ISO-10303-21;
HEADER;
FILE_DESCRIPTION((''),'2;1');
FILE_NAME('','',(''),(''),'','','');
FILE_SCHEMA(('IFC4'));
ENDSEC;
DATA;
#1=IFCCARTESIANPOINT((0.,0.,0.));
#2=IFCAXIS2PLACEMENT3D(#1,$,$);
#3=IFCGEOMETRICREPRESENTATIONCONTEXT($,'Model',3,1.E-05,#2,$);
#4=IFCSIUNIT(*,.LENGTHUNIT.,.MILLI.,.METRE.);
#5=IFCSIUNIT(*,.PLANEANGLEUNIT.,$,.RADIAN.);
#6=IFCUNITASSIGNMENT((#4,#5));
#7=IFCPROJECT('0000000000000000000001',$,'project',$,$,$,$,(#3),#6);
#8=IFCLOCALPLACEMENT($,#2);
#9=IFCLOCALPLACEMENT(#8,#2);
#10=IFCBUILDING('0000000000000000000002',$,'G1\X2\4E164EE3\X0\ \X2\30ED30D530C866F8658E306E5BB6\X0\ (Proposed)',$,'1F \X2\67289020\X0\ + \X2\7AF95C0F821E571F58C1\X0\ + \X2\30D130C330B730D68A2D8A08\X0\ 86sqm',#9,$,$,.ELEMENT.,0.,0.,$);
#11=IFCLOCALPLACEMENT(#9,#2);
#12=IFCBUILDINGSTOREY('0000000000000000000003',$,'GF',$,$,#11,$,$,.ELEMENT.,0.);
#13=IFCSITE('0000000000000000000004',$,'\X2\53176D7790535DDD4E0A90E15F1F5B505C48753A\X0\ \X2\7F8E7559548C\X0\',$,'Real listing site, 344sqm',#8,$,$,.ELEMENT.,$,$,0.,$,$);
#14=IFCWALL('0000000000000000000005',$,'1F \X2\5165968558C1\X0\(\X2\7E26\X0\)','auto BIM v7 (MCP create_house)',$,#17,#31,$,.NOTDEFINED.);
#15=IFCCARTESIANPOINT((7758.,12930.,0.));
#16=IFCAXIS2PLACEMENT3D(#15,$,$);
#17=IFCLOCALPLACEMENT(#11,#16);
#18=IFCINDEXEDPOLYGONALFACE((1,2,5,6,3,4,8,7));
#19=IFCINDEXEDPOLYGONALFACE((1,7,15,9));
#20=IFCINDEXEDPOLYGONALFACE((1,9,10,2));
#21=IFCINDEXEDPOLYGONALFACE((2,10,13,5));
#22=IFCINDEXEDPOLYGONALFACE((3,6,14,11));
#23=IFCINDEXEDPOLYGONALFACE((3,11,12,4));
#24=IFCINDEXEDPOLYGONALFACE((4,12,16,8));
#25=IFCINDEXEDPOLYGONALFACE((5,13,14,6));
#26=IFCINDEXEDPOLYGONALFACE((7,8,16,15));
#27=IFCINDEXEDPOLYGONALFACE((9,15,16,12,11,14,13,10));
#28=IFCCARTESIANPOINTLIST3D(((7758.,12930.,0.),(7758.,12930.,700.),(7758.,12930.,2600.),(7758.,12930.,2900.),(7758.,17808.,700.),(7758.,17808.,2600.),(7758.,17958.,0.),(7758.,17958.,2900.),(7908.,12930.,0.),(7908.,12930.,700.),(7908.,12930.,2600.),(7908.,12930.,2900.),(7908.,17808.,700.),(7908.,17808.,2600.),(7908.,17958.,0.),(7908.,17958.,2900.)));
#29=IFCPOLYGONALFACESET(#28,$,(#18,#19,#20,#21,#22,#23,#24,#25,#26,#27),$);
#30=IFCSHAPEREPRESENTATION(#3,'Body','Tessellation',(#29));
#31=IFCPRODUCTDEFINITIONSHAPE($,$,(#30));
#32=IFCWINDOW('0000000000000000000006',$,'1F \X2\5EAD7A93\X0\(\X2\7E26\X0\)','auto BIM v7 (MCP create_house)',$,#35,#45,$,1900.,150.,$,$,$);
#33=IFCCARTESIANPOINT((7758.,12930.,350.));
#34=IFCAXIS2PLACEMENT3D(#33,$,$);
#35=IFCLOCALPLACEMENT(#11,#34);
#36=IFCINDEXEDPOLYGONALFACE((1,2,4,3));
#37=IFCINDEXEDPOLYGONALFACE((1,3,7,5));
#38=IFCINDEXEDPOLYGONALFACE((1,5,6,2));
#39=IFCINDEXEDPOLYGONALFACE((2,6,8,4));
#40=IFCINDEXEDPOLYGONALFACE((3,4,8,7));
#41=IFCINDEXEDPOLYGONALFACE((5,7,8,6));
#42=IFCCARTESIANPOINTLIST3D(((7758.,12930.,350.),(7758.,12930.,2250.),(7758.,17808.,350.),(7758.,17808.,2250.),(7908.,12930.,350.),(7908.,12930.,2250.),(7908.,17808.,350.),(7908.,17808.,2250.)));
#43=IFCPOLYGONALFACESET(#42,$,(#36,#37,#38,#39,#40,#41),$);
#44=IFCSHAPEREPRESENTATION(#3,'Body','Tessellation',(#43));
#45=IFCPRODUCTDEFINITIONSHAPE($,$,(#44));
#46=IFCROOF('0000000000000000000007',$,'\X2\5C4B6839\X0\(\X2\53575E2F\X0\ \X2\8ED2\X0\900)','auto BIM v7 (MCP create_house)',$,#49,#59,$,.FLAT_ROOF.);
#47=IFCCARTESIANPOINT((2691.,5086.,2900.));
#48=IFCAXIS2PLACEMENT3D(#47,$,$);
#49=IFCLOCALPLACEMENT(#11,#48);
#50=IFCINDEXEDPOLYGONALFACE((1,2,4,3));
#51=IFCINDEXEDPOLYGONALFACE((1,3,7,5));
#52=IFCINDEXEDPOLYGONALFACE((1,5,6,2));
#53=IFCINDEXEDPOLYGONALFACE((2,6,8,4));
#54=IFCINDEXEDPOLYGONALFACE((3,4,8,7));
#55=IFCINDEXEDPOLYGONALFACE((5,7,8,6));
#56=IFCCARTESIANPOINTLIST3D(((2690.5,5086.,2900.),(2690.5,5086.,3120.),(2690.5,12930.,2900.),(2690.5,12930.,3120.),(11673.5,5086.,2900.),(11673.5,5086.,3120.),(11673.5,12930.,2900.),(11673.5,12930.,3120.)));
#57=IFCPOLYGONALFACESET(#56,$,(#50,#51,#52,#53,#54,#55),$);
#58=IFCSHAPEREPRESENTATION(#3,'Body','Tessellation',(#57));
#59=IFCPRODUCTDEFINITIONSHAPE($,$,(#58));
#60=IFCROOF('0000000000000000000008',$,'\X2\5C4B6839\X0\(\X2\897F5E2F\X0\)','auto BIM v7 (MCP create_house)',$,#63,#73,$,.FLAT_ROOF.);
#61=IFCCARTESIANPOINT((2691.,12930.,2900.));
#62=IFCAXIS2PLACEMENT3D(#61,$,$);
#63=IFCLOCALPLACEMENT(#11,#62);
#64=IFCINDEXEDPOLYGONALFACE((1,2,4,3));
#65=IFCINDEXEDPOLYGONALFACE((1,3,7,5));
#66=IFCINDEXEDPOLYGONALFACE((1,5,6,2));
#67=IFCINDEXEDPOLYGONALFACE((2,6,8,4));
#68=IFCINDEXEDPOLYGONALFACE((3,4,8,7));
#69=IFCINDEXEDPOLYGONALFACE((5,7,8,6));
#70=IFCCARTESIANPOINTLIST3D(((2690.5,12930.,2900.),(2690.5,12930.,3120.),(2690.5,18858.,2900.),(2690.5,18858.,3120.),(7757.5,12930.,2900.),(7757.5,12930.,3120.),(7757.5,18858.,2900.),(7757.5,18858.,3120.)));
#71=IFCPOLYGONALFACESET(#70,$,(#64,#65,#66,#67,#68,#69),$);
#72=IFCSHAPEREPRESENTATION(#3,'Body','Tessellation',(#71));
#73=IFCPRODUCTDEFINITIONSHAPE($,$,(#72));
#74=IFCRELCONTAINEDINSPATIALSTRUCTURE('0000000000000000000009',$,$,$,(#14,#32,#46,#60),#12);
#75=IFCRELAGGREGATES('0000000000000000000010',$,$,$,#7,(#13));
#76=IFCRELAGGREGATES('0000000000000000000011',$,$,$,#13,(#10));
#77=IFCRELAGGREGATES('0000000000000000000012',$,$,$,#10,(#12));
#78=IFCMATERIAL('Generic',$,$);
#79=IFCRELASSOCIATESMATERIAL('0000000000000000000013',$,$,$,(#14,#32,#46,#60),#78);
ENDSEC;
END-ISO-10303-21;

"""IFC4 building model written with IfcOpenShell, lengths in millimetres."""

from ifc_helpers import new_model, si_unit, frame, frame_2d, origin, place, context, project, spatial, rectangle, extrude, material, element, fill, save


model = new_model("IFC4")

# Units and contexts
model_context = context("Model", 3, precision=1e-05, world=origin())
ifc_project = project(units=[si_unit("LENGTHUNIT", "METRE", prefix="MILLI"), si_unit("PLANEANGLEUNIT", "RADIAN")], contexts=[model_context])

# Site, building, storey
site_placement = place(None, origin())
site = spatial("IfcSite", under=ifc_project, at=site_placement, Name="北海道川上郡弟子屈町 美留和", ObjectType="Real listing site, 344sqm", CompositionType="ELEMENT", RefElevation=0.0)
building_placement = place(site_placement, origin())
building = spatial("IfcBuilding", under=site, at=building_placement, Name="G1世代 ロフト書斎の家 (Proposed)", ObjectType="1F 木造 + 竹小舞土壁 + パッシブ設計 86sqm", CompositionType="ELEMENT", ElevationOfRefHeight=0.0, ElevationOfTerrain=0.0)
storey_placement = place(building_placement, origin())
storey = spatial("IfcBuildingStorey", under=building, at=storey_placement, Name="GF", CompositionType="ELEMENT", Elevation=0.0)

# Shared definitions
ifc_material = material(Name="Generic")

# Wall, opening, window
wall_1_placement = place(storey_placement, frame((7758.0, 12930.0, 0.0)))
wall_1 = element("IfcWall", 1, at=wall_1_placement, inside=storey, material=ifc_material, Name="1F 入隅壁(縦)", Description="auto BIM v7 (MCP create_house)", PredefinedType="NOTDEFINED", context=model_context, shape_type="SweptSolid", body=[
    extrude(rectangle(XDim=150.0, YDim=5028.0, at=frame_2d((75.0, 2514.0))), frame((7758.0, 12930.0, 0.0)), (0.0, 0.0, 1.0), 2900.0),
])
opening_1_placement = place(storey_placement, frame((7758.0, 12930.0, 350.0)))
opening_1 = element("IfcOpeningElement", 2, at=opening_1_placement, cuts=wall_1, PredefinedType="NOTDEFINED", context=model_context, shape_type="SweptSolid", body=[
    extrude(rectangle(XDim=150.0, YDim=4878.0, at=frame_2d((75.0, 2439.0))), frame((7758.0, 12930.0, 350.0)), (0.0, 0.0, 1.0), 1900.0),
])
window_1_placement = place(storey_placement, frame((7758.0, 12930.0, 350.0)))
window_1 = element("IfcWindow", 3, at=window_1_placement, inside=storey, material=ifc_material, Name="1F 庭窓(縦)", Description="auto BIM v7 (MCP create_house)", OverallHeight=1900.0, OverallWidth=150.0, context=model_context, shape_type="SweptSolid", body=[
    extrude(rectangle(XDim=150.0, YDim=4878.0, at=frame_2d((75.0, 2439.0))), frame((7758.0, 12930.0, 350.0)), (0.0, 0.0, 1.0), 1900.0),
])
fill(opening_1, window_1)

# Roofs
roof_1_placement = place(storey_placement, frame((2691.0, 5086.0, 2900.0)))
element("IfcRoof", 4, at=roof_1_placement, inside=storey, material=ifc_material, Name="屋根(南帯 軒900)", Description="auto BIM v7 (MCP create_house)", PredefinedType="FLAT_ROOF", context=model_context, shape_type="SweptSolid", body=[
    extrude(rectangle(XDim=8983.0, YDim=7844.0, at=frame_2d((4491.0, 3922.0))), frame((2691.0, 5086.0, 2900.0)), (0.0, 0.0, 1.0), 220.0),
])
roof_2_placement = place(storey_placement, frame((2691.0, 12930.0, 2900.0)))
element("IfcRoof", 5, at=roof_2_placement, inside=storey, material=ifc_material, Name="屋根(西帯)", Description="auto BIM v7 (MCP create_house)", PredefinedType="FLAT_ROOF", context=model_context, shape_type="SweptSolid", body=[
    extrude(rectangle(XDim=5067.0, YDim=5928.0, at=frame_2d((2533.0, 2964.0))), frame((2691.0, 12930.0, 2900.0)), (0.0, 0.0, 1.0), 220.0),
])

save(model, "model.ifc")
